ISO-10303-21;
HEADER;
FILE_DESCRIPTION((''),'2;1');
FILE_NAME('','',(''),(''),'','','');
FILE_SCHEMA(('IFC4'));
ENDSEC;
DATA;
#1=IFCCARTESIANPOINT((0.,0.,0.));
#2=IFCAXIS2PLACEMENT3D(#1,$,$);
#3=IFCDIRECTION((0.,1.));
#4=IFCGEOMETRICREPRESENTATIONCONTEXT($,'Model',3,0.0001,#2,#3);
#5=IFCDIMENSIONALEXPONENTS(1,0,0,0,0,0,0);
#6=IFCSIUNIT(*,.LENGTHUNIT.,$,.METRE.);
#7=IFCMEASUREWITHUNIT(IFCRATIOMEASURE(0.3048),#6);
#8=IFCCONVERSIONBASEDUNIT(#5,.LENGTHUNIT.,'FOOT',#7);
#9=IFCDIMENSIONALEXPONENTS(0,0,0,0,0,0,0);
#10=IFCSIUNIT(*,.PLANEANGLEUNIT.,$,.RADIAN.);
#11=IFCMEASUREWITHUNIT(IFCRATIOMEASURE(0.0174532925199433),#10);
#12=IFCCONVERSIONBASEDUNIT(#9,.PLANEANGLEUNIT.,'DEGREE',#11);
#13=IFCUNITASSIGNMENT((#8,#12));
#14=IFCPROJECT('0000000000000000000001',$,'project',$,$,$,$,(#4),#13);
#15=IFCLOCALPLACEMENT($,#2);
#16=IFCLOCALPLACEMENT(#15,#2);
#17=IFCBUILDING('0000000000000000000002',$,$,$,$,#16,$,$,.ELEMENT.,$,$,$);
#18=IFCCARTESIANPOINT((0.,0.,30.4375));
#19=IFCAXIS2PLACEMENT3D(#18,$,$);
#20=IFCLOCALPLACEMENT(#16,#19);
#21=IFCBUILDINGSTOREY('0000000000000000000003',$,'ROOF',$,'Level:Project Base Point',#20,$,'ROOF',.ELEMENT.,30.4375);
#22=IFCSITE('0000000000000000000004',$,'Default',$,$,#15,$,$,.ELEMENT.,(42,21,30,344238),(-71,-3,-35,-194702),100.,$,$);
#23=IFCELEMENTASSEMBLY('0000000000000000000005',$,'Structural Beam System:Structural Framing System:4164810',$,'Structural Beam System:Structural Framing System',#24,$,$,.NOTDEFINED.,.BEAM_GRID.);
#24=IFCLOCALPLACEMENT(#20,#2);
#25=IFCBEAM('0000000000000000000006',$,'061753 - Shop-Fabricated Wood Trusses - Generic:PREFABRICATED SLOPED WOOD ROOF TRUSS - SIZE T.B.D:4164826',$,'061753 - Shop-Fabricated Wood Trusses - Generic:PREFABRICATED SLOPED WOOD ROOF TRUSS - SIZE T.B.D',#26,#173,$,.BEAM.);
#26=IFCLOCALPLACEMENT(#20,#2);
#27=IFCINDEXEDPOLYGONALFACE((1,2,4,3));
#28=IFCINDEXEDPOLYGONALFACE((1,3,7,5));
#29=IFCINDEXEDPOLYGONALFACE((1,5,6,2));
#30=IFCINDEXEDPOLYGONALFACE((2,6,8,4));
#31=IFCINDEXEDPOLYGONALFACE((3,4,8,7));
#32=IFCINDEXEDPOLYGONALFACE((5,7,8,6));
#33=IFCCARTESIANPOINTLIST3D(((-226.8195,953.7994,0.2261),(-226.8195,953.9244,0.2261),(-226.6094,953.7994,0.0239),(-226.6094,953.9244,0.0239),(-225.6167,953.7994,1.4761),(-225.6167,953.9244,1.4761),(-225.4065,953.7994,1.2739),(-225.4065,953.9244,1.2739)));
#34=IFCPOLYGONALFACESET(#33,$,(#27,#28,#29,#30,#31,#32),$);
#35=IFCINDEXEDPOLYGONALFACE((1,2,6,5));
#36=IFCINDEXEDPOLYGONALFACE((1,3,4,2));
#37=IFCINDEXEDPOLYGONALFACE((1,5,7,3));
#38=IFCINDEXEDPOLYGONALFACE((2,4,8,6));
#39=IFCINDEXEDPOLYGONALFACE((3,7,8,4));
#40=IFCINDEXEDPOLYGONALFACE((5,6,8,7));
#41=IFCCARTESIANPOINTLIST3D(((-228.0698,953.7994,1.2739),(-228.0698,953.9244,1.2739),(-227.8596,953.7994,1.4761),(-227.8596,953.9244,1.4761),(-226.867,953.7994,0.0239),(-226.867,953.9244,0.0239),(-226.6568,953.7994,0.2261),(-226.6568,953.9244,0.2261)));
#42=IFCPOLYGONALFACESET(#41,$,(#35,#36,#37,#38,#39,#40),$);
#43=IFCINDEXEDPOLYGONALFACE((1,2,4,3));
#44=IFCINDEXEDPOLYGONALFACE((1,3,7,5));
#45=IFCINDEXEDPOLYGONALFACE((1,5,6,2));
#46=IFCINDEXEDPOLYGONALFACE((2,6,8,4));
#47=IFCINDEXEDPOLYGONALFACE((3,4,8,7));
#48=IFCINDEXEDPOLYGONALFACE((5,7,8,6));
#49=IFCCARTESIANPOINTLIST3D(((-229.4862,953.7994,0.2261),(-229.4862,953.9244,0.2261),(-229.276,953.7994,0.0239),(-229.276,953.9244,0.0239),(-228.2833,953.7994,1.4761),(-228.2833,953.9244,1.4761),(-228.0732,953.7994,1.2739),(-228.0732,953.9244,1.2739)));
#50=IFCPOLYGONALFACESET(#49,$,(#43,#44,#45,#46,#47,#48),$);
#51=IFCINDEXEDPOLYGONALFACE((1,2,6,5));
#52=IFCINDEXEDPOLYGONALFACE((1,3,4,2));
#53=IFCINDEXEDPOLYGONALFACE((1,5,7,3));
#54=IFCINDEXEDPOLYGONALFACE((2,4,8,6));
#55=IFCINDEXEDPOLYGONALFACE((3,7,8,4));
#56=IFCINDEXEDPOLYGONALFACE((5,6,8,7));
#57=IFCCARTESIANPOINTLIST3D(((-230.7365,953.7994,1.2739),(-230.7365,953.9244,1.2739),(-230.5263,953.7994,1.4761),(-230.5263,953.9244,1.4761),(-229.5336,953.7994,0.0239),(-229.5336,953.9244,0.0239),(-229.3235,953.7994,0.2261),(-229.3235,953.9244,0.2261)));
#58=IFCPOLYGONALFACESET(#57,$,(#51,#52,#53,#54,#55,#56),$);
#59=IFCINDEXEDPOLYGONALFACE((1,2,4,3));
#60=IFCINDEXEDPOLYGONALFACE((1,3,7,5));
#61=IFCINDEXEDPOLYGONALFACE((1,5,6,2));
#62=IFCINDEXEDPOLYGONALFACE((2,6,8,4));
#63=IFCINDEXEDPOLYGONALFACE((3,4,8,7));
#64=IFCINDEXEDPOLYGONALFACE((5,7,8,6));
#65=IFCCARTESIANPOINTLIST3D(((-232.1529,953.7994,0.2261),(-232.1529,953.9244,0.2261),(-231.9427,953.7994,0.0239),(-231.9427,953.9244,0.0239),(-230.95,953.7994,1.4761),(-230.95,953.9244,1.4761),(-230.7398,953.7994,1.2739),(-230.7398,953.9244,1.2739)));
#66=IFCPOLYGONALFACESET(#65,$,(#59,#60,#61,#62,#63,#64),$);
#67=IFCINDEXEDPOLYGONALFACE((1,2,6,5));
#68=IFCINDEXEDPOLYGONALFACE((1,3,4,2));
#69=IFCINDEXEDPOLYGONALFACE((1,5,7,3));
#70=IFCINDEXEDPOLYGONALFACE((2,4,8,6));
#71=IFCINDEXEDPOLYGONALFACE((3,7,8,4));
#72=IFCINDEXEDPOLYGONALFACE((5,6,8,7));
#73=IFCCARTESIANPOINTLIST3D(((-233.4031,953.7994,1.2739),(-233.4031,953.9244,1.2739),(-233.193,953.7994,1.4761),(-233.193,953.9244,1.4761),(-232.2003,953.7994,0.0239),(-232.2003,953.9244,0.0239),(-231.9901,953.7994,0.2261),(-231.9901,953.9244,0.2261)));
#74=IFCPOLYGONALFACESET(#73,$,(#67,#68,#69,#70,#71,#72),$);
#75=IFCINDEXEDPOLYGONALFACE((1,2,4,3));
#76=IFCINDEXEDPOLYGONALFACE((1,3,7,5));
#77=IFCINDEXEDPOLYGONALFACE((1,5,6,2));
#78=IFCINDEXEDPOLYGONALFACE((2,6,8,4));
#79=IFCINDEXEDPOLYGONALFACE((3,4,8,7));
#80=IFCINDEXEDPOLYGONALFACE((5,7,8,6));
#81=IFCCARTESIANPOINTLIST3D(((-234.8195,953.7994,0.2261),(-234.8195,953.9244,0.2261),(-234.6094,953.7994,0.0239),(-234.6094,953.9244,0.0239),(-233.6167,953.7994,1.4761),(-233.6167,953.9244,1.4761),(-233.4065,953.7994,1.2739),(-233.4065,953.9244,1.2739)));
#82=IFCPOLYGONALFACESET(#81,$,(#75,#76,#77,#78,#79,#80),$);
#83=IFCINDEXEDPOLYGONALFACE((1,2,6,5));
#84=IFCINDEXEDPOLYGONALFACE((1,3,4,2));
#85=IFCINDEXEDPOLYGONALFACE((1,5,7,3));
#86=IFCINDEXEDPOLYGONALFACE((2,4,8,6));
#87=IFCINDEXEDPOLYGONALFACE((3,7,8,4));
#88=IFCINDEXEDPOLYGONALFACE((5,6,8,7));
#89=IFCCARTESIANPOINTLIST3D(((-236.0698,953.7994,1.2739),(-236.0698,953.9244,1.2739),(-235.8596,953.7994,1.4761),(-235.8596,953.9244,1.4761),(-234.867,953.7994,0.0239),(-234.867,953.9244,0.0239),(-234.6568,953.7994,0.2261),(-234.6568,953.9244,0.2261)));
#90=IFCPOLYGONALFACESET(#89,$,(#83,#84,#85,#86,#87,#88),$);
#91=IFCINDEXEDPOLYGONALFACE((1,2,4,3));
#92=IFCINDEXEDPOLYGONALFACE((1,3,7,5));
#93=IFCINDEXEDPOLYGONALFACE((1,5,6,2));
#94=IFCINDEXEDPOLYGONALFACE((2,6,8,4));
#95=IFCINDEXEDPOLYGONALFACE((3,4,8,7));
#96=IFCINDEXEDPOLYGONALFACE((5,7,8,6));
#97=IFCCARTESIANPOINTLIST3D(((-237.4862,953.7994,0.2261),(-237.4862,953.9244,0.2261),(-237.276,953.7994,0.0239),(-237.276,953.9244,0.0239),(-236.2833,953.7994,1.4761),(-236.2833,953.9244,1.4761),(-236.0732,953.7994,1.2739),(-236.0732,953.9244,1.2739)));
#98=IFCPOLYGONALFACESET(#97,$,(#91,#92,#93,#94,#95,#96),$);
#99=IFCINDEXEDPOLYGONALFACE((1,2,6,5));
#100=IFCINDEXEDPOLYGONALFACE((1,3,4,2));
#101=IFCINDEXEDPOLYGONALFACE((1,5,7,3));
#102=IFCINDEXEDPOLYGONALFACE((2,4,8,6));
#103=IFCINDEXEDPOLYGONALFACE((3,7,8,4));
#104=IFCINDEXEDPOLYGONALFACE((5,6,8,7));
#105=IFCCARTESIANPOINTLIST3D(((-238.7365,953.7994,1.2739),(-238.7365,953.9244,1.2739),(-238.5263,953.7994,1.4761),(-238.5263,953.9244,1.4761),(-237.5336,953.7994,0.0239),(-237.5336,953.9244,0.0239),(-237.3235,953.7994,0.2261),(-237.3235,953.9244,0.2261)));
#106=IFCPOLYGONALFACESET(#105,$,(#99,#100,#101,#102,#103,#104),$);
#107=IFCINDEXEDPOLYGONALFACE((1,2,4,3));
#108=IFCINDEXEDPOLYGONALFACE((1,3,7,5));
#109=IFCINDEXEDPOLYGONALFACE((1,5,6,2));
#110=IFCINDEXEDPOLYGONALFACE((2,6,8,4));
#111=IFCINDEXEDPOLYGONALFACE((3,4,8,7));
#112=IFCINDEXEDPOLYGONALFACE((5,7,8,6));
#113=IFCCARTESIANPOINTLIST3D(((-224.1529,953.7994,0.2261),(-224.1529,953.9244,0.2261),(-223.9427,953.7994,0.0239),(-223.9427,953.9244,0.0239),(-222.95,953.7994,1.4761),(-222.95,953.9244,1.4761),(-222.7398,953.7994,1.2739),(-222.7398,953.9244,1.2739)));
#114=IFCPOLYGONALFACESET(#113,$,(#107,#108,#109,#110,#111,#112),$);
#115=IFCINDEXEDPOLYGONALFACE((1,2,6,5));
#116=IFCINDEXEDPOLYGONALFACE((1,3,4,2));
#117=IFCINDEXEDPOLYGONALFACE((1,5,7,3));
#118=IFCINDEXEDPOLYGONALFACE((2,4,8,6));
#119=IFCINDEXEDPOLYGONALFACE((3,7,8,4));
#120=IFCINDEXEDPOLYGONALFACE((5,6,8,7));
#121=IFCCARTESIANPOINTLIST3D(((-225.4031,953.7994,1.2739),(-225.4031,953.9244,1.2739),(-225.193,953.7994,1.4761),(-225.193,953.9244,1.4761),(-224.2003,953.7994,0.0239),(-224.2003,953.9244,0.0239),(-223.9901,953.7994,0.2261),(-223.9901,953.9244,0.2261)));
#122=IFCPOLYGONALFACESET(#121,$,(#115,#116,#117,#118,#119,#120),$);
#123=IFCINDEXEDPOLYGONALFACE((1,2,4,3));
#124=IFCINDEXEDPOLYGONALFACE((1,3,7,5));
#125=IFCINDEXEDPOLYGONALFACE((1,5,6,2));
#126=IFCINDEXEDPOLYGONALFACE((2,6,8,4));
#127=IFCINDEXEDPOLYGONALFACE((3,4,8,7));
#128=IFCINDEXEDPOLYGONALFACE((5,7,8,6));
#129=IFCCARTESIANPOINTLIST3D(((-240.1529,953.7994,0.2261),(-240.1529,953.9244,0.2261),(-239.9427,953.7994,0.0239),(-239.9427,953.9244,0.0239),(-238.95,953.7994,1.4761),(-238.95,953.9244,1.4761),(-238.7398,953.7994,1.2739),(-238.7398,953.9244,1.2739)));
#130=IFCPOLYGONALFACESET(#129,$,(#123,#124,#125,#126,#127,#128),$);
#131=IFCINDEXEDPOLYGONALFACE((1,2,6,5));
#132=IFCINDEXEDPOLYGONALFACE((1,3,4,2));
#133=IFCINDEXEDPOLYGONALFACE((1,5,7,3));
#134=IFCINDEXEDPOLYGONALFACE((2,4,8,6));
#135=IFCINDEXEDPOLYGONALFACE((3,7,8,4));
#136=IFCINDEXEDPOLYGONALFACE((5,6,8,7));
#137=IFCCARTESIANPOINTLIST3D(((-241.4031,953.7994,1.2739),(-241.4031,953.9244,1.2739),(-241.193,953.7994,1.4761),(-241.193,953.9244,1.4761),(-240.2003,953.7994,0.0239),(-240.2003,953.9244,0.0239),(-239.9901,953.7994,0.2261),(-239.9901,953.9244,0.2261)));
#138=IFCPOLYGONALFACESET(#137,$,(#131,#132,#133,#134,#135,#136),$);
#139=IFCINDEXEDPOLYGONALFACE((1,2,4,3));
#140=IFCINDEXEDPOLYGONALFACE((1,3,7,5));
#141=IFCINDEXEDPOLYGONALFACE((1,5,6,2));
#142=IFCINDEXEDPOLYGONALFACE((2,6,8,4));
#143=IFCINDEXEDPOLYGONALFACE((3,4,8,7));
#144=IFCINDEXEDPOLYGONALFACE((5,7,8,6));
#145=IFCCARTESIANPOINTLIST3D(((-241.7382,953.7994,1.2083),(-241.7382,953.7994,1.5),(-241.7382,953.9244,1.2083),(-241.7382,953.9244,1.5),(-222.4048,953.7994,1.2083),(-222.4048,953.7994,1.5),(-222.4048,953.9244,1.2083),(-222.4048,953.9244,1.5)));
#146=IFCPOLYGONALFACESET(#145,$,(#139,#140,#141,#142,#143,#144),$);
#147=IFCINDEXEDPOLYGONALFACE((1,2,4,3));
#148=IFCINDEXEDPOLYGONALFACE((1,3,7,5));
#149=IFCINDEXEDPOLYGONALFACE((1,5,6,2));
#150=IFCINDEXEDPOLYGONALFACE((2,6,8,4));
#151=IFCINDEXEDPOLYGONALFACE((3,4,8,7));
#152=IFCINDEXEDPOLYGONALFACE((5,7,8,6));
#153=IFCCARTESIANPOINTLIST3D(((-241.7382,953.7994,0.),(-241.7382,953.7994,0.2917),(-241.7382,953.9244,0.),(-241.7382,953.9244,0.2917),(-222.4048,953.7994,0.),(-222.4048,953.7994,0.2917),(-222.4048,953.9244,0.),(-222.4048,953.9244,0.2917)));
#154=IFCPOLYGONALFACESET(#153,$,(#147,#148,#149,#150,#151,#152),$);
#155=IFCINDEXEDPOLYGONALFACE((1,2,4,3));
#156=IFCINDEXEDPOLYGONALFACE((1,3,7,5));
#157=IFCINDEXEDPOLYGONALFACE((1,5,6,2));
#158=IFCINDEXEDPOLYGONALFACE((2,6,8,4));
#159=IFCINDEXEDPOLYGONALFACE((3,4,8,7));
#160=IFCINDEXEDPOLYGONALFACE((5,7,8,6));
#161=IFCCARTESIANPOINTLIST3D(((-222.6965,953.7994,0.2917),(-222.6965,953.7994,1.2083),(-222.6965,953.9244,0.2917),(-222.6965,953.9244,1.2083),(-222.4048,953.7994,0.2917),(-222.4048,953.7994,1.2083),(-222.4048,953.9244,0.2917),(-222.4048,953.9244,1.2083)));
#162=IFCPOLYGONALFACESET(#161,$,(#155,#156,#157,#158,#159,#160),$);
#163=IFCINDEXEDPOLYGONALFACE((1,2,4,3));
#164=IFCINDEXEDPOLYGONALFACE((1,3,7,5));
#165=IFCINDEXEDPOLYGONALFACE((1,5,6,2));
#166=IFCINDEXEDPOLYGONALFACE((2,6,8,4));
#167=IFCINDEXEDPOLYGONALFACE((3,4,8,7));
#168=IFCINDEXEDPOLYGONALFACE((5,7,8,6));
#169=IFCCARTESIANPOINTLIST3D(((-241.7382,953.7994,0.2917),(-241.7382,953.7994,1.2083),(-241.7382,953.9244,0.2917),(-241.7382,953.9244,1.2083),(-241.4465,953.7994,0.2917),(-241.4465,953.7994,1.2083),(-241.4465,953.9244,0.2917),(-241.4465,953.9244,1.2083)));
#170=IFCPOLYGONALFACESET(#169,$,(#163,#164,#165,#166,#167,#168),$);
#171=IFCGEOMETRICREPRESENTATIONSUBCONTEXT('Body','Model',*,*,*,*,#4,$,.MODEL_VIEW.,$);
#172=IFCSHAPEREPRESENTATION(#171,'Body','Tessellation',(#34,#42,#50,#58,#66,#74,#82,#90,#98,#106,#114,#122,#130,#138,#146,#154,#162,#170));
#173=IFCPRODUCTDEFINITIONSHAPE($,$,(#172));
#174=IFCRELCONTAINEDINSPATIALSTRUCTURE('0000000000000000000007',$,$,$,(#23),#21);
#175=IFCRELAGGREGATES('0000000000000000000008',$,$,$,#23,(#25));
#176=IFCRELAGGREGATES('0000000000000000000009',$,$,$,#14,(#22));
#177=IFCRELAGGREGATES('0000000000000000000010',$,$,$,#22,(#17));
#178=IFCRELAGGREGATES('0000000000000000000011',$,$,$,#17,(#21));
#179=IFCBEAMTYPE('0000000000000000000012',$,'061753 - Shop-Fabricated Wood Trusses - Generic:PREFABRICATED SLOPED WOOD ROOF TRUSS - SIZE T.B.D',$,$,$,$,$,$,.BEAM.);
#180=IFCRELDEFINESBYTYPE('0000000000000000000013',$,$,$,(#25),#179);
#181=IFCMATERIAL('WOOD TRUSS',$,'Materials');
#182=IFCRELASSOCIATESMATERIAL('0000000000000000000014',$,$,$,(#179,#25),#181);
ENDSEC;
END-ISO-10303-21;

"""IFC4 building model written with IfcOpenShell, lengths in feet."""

from ifc_helpers import new_model, entity, si_unit, converted_unit, direction, frame, frame_2d, origin, origin_2d_with_axis, place, context, subcontext, project, spatial, rectangle, extrude, source, transform, mapped, material, material_profile, profile_set, profile_usage, type_object, type_shapes, element, aggregate, save


model = new_model("IFC4")

# Units and contexts
model_context = context("Model", 3, precision=0.0001, world=origin(), true_north=direction((0.0, 1.0)))
body_context = subcontext(model_context, "Body", "Model", "MODEL_VIEW")
ifc_project = project(units=[converted_unit("LENGTHUNIT", "FOOT", entity("IfcRatioMeasure", 0.3048), si_unit("LENGTHUNIT", "METRE"), dimensions=[1, 0, 0, 0, 0, 0, 0]), converted_unit("PLANEANGLEUNIT", "DEGREE", entity("IfcRatioMeasure", 0.0174532925199433), si_unit("PLANEANGLEUNIT", "RADIAN"), dimensions=[0, 0, 0, 0, 0, 0, 0])], contexts=[model_context])

# Site, building, storey
site_placement = place(None, origin())
site = spatial("IfcSite", under=ifc_project, at=site_placement, Name="Default", CompositionType="ELEMENT", RefLatitude=(42, 21, 30, 344238), RefLongitude=(-71, -3, -35, -194702), RefElevation=100.0)
building_placement = place(site_placement, origin())
building = spatial("IfcBuilding", under=site, at=building_placement, CompositionType="ELEMENT")
storey_placement = place(building_placement, frame((0.0, 0.0, 30.4375)))
storey = spatial("IfcBuildingStorey", under=building, at=storey_placement, Name="ROOF", ObjectType="Level:Project Base Point", LongName="ROOF", CompositionType="ELEMENT", Elevation=30.4375)

# Element assembly, beam
assembly_1_placement = place(storey_placement, origin())
assembly_1 = element("IfcElementAssembly", 1, at=assembly_1_placement, inside=storey, Name="Structural Beam System:Structural Framing System:4164810", ObjectType="Structural Beam System:Structural Framing System", AssemblyPlace="NOTDEFINED", PredefinedType="BEAM_GRID")
ifc_material_1 = material(Name="WOOD TRUSS", Category="Materials")
ifc_material_profile_1 = material_profile(ifc_material_1, rectangle(XDim=1.7347, YDim=0.125, at=origin_2d_with_axis()), Name="PREFABRICATED SLOPED WOOD ROOF TRUSS - SIZE T.B.D")
ifc_material_profile_2 = material_profile(ifc_material_1, rectangle(XDim=1.7347, YDim=0.125, at=frame_2d((0.0, 0.0), x_axis=(1.0, 0.0))), Name="PREFABRICATED SLOPED WOOD ROOF TRUSS - SIZE T.B.D")
ifc_material_profile_3 = material_profile(ifc_material_1, rectangle(XDim=1.7347, YDim=0.125, at=origin_2d_with_axis()), Name="PREFABRICATED SLOPED WOOD ROOF TRUSS - SIZE T.B.D")
ifc_material_profile_4 = material_profile(ifc_material_1, rectangle(XDim=1.7347, YDim=0.125, at=origin_2d_with_axis()), Name="PREFABRICATED SLOPED WOOD ROOF TRUSS - SIZE T.B.D")
ifc_material_profile_5 = material_profile(ifc_material_1, rectangle(XDim=1.7347, YDim=0.125, at=frame_2d((0.0, 0.0), x_axis=(1.0, 0.0))), Name="PREFABRICATED SLOPED WOOD ROOF TRUSS - SIZE T.B.D")
ifc_material_profile_6 = material_profile(ifc_material_1, rectangle(XDim=1.7347, YDim=0.125, at=frame_2d((0.0, 0.0), x_axis=(1.0, 0.0))), Name="PREFABRICATED SLOPED WOOD ROOF TRUSS - SIZE T.B.D")
ifc_material_profile_7 = material_profile(ifc_material_1, rectangle(XDim=1.7347, YDim=0.125, at=frame_2d((0.0, 0.0), x_axis=(1.0, 0.0))), Name="PREFABRICATED SLOPED WOOD ROOF TRUSS - SIZE T.B.D")
ifc_material_profile_8 = material_profile(ifc_material_1, rectangle(XDim=1.7347, YDim=0.125, at=frame_2d((0.0, 0.0), x_axis=(1.0, 0.0))), Name="PREFABRICATED SLOPED WOOD ROOF TRUSS - SIZE T.B.D")
ifc_material_profile_9 = material_profile(ifc_material_1, rectangle(XDim=1.7347, YDim=0.125, at=origin_2d_with_axis()), Name="PREFABRICATED SLOPED WOOD ROOF TRUSS - SIZE T.B.D")
ifc_material_profile_10 = material_profile(ifc_material_1, rectangle(XDim=1.7347, YDim=0.125, at=frame_2d((0.0, 0.0), x_axis=(1.0, 0.0))), Name="PREFABRICATED SLOPED WOOD ROOF TRUSS - SIZE T.B.D")
ifc_material_profile_11 = material_profile(ifc_material_1, rectangle(XDim=0.2917, YDim=0.125, at=frame_2d((0.0, 0.0), x_axis=(1.0, 0.0))), Name="PREFABRICATED SLOPED WOOD ROOF TRUSS - SIZE T.B.D")
ifc_material_profile_12 = material_profile(ifc_material_1, rectangle(XDim=0.2917, YDim=0.125, at=frame_2d((0.0, 0.0), x_axis=(1.0, 0.0))), Name="PREFABRICATED SLOPED WOOD ROOF TRUSS - SIZE T.B.D")
ifc_material_profile_13 = material_profile(ifc_material_1, rectangle(XDim=0.9167, YDim=0.125, at=frame_2d((0.0, 0.0), x_axis=(1.0, 0.0))), Name="PREFABRICATED SLOPED WOOD ROOF TRUSS - SIZE T.B.D")
ifc_material_profile_14 = material_profile(ifc_material_1, rectangle(XDim=0.9167, YDim=0.125, at=frame_2d((0.0, 0.0), x_axis=(1.0, 0.0))), Name="PREFABRICATED SLOPED WOOD ROOF TRUSS - SIZE T.B.D")
ifc_profile_set_1 = profile_set([ifc_material_profile_1, ifc_material_profile_2, ifc_material_profile_3, ifc_material_profile_4, ifc_material_profile_5, ifc_material_profile_6, ifc_material_profile_7, ifc_material_profile_8, ifc_material_profile_9, ifc_material_profile_10, ifc_material_profile_11, ifc_material_profile_12, ifc_material_profile_13, ifc_material_profile_14], Name="PREFABRICATED SLOPED WOOD ROOF TRUSS - SIZE T.B.D")
beam_type_1 = type_object("IfcBeamType", Name="061753 - Shop-Fabricated Wood Trusses - Generic:PREFABRICATED SLOPED WOOD ROOF TRUSS - SIZE T.B.D", PredefinedType="BEAM", material=ifc_profile_set_1)
shared_shape_1 = source(origin(), body_context, "Body", "SweptSolid", [
    extrude(rectangle(XDim=1.7347, YDim=0.125, at=frame_2d((0.0, 0.0), x_axis=(1.0, 0.0))), frame((5.8534, 0.0, 0.1011), z_axis=(0.720569, 0.0, -0.693383), x_axis=(0.693383, 0.0, 0.720569)), (0.0, 0.0, 1.0), 0.2917),
    extrude(rectangle(XDim=1.7347, YDim=0.125, at=frame_2d((0.0, 0.0), x_axis=(1.0, 0.0))), frame((4.6031, 0.0, -0.1011), z_axis=(0.720569, 0.0, 0.693383), x_axis=(0.693383, 0.0, -0.720569)), (0.0, 0.0, 1.0), 0.2917),
    extrude(rectangle(XDim=1.7347, YDim=0.125, at=frame_2d((0.0, 0.0), x_axis=(1.0, 0.0))), frame((3.1867, 0.0, 0.1011), z_axis=(0.720569, 0.0, -0.693383), x_axis=(0.693383, 0.0, 0.720569)), (0.0, 0.0, 1.0), 0.2917),
    extrude(rectangle(XDim=1.7347, YDim=0.125, at=frame_2d((0.0, 0.0), x_axis=(1.0, 0.0))), frame((1.9364, 0.0, -0.1011), z_axis=(0.720569, 0.0, 0.693383), x_axis=(0.693383, 0.0, -0.720569)), (0.0, 0.0, 1.0), 0.2917),
    extrude(rectangle(XDim=1.7347, YDim=0.125, at=frame_2d((0.0, 0.0), x_axis=(1.0, 0.0))), frame((0.5201, 0.0, 0.1011), z_axis=(0.720569, 0.0, -0.693383), x_axis=(0.693383, 0.0, 0.720569)), (0.0, 0.0, 1.0), 0.2917),
    extrude(rectangle(XDim=1.7347, YDim=0.125, at=origin_2d_with_axis()), frame((-0.7302, 0.0, -0.1011), z_axis=(0.720569, 0.0, 0.693383), x_axis=(0.693383, 0.0, -0.720569)), (0.0, 0.0, 1.0), 0.2917),
    extrude(rectangle(XDim=1.7347, YDim=0.125, at=frame_2d((0.0, 0.0), x_axis=(1.0, 0.0))), frame((-2.1466, 0.0, 0.1011), z_axis=(0.720569, 0.0, -0.693383), x_axis=(0.693383, 0.0, 0.720569)), (0.0, 0.0, 1.0), 0.2917),
    extrude(rectangle(XDim=1.7347, YDim=0.125, at=frame_2d((0.0, 0.0), x_axis=(1.0, 0.0))), frame((-3.3969, 0.0, -0.1011), z_axis=(0.720569, 0.0, 0.693383), x_axis=(0.693383, 0.0, -0.720569)), (0.0, 0.0, 1.0), 0.2917),
    extrude(rectangle(XDim=1.7347, YDim=0.125, at=origin_2d_with_axis()), frame((-4.8133, 0.0, 0.1011), z_axis=(0.720569, 0.0, -0.693383), x_axis=(0.693383, 0.0, 0.720569)), (0.0, 0.0, 1.0), 0.2917),
    extrude(rectangle(XDim=1.7347, YDim=0.125, at=frame_2d((0.0, 0.0), x_axis=(1.0, 0.0))), frame((-6.0636, 0.0, -0.1011), z_axis=(0.720569, 0.0, 0.693383), x_axis=(0.693383, 0.0, -0.720569)), (0.0, 0.0, 1.0), 0.2917),
    extrude(rectangle(XDim=1.7347, YDim=0.125, at=frame_2d((0.0, 0.0), x_axis=(1.0, 0.0))), frame((8.5201, 0.0, 0.1011), z_axis=(0.720569, 0.0, -0.693383), x_axis=(0.693383, 0.0, 0.720569)), (0.0, 0.0, 1.0), 0.2917),
    extrude(rectangle(XDim=1.7347, YDim=0.125, at=origin_2d_with_axis()), frame((7.2698, 0.0, -0.1011), z_axis=(0.720569, 0.0, 0.693383), x_axis=(0.693383, 0.0, -0.720569)), (0.0, 0.0, 1.0), 0.2917),
    extrude(rectangle(XDim=1.7347, YDim=0.125, at=frame_2d((0.0, 0.0), x_axis=(1.0, 0.0))), frame((-7.4799, 0.0, 0.1011), z_axis=(0.720569, 0.0, -0.693383), x_axis=(0.693383, 0.0, 0.720569)), (0.0, 0.0, 1.0), 0.2917),
    extrude(rectangle(XDim=1.7347, YDim=0.125, at=origin_2d_with_axis()), frame((-8.7302, 0.0, -0.1011), z_axis=(0.720569, 0.0, 0.693383), x_axis=(0.693383, 0.0, -0.720569)), (0.0, 0.0, 1.0), 0.2917),
    extrude(rectangle(XDim=0.2917, YDim=0.125, at=frame_2d((0.0, 0.0), x_axis=(1.0, 0.0))), frame((-9.6667, 0.0, 0.6042), z_axis=(1.0, 0.0, 0.0), x_axis=(0.0, 0.0, -1.0)), (0.0, 0.0, 1.0), 19.3333),
    extrude(rectangle(XDim=0.2917, YDim=0.125, at=frame_2d((0.0, 0.0), x_axis=(1.0, 0.0))), frame((-9.6667, 0.0, -0.6042), z_axis=(1.0, 0.0, 0.0), x_axis=(0.0, 0.0, -1.0)), (0.0, 0.0, 1.0), 19.3333),
    extrude(rectangle(XDim=0.9167, YDim=0.125, at=frame_2d((0.0, 0.0), x_axis=(1.0, 0.0))), frame((9.375, 0.0, 0.0), z_axis=(1.0, 0.0, 0.0), x_axis=(0.0, 0.0, -1.0)), (0.0, 0.0, 1.0), 0.2917),
    extrude(rectangle(XDim=0.9167, YDim=0.125, at=frame_2d((0.0, 0.0), x_axis=(1.0, 0.0))), frame((-9.6667, 0.0, 0.0), z_axis=(1.0, 0.0, 0.0), x_axis=(0.0, 0.0, -1.0)), (0.0, 0.0, 1.0), 0.2917),
])
type_shapes(beam_type_1, [shared_shape_1])
ifc_profile_usage_1 = profile_usage(ifc_profile_set_1, cardinal=8)
beam_1_placement = place(assembly_1_placement, frame((-232.0715, 953.8619, 0.75)))
beam_1 = element("IfcBeam", 2, at=beam_1_placement, type_object=beam_type_1, material=ifc_profile_usage_1, Name="061753 - Shop-Fabricated Wood Trusses - Generic:PREFABRICATED SLOPED WOOD ROOF TRUSS - SIZE T.B.D:4164826", ObjectType="061753 - Shop-Fabricated Wood Trusses - Generic:PREFABRICATED SLOPED WOOD ROOF TRUSS - SIZE T.B.D", PredefinedType="BEAM", context=body_context, shape_type="MappedRepresentation", body=[
    mapped(shared_shape_1, transform((0.0, 0.0, 0.0), scale=1.0)),
])
aggregate(assembly_1, [beam_1])

save(model, "model.ifc")
